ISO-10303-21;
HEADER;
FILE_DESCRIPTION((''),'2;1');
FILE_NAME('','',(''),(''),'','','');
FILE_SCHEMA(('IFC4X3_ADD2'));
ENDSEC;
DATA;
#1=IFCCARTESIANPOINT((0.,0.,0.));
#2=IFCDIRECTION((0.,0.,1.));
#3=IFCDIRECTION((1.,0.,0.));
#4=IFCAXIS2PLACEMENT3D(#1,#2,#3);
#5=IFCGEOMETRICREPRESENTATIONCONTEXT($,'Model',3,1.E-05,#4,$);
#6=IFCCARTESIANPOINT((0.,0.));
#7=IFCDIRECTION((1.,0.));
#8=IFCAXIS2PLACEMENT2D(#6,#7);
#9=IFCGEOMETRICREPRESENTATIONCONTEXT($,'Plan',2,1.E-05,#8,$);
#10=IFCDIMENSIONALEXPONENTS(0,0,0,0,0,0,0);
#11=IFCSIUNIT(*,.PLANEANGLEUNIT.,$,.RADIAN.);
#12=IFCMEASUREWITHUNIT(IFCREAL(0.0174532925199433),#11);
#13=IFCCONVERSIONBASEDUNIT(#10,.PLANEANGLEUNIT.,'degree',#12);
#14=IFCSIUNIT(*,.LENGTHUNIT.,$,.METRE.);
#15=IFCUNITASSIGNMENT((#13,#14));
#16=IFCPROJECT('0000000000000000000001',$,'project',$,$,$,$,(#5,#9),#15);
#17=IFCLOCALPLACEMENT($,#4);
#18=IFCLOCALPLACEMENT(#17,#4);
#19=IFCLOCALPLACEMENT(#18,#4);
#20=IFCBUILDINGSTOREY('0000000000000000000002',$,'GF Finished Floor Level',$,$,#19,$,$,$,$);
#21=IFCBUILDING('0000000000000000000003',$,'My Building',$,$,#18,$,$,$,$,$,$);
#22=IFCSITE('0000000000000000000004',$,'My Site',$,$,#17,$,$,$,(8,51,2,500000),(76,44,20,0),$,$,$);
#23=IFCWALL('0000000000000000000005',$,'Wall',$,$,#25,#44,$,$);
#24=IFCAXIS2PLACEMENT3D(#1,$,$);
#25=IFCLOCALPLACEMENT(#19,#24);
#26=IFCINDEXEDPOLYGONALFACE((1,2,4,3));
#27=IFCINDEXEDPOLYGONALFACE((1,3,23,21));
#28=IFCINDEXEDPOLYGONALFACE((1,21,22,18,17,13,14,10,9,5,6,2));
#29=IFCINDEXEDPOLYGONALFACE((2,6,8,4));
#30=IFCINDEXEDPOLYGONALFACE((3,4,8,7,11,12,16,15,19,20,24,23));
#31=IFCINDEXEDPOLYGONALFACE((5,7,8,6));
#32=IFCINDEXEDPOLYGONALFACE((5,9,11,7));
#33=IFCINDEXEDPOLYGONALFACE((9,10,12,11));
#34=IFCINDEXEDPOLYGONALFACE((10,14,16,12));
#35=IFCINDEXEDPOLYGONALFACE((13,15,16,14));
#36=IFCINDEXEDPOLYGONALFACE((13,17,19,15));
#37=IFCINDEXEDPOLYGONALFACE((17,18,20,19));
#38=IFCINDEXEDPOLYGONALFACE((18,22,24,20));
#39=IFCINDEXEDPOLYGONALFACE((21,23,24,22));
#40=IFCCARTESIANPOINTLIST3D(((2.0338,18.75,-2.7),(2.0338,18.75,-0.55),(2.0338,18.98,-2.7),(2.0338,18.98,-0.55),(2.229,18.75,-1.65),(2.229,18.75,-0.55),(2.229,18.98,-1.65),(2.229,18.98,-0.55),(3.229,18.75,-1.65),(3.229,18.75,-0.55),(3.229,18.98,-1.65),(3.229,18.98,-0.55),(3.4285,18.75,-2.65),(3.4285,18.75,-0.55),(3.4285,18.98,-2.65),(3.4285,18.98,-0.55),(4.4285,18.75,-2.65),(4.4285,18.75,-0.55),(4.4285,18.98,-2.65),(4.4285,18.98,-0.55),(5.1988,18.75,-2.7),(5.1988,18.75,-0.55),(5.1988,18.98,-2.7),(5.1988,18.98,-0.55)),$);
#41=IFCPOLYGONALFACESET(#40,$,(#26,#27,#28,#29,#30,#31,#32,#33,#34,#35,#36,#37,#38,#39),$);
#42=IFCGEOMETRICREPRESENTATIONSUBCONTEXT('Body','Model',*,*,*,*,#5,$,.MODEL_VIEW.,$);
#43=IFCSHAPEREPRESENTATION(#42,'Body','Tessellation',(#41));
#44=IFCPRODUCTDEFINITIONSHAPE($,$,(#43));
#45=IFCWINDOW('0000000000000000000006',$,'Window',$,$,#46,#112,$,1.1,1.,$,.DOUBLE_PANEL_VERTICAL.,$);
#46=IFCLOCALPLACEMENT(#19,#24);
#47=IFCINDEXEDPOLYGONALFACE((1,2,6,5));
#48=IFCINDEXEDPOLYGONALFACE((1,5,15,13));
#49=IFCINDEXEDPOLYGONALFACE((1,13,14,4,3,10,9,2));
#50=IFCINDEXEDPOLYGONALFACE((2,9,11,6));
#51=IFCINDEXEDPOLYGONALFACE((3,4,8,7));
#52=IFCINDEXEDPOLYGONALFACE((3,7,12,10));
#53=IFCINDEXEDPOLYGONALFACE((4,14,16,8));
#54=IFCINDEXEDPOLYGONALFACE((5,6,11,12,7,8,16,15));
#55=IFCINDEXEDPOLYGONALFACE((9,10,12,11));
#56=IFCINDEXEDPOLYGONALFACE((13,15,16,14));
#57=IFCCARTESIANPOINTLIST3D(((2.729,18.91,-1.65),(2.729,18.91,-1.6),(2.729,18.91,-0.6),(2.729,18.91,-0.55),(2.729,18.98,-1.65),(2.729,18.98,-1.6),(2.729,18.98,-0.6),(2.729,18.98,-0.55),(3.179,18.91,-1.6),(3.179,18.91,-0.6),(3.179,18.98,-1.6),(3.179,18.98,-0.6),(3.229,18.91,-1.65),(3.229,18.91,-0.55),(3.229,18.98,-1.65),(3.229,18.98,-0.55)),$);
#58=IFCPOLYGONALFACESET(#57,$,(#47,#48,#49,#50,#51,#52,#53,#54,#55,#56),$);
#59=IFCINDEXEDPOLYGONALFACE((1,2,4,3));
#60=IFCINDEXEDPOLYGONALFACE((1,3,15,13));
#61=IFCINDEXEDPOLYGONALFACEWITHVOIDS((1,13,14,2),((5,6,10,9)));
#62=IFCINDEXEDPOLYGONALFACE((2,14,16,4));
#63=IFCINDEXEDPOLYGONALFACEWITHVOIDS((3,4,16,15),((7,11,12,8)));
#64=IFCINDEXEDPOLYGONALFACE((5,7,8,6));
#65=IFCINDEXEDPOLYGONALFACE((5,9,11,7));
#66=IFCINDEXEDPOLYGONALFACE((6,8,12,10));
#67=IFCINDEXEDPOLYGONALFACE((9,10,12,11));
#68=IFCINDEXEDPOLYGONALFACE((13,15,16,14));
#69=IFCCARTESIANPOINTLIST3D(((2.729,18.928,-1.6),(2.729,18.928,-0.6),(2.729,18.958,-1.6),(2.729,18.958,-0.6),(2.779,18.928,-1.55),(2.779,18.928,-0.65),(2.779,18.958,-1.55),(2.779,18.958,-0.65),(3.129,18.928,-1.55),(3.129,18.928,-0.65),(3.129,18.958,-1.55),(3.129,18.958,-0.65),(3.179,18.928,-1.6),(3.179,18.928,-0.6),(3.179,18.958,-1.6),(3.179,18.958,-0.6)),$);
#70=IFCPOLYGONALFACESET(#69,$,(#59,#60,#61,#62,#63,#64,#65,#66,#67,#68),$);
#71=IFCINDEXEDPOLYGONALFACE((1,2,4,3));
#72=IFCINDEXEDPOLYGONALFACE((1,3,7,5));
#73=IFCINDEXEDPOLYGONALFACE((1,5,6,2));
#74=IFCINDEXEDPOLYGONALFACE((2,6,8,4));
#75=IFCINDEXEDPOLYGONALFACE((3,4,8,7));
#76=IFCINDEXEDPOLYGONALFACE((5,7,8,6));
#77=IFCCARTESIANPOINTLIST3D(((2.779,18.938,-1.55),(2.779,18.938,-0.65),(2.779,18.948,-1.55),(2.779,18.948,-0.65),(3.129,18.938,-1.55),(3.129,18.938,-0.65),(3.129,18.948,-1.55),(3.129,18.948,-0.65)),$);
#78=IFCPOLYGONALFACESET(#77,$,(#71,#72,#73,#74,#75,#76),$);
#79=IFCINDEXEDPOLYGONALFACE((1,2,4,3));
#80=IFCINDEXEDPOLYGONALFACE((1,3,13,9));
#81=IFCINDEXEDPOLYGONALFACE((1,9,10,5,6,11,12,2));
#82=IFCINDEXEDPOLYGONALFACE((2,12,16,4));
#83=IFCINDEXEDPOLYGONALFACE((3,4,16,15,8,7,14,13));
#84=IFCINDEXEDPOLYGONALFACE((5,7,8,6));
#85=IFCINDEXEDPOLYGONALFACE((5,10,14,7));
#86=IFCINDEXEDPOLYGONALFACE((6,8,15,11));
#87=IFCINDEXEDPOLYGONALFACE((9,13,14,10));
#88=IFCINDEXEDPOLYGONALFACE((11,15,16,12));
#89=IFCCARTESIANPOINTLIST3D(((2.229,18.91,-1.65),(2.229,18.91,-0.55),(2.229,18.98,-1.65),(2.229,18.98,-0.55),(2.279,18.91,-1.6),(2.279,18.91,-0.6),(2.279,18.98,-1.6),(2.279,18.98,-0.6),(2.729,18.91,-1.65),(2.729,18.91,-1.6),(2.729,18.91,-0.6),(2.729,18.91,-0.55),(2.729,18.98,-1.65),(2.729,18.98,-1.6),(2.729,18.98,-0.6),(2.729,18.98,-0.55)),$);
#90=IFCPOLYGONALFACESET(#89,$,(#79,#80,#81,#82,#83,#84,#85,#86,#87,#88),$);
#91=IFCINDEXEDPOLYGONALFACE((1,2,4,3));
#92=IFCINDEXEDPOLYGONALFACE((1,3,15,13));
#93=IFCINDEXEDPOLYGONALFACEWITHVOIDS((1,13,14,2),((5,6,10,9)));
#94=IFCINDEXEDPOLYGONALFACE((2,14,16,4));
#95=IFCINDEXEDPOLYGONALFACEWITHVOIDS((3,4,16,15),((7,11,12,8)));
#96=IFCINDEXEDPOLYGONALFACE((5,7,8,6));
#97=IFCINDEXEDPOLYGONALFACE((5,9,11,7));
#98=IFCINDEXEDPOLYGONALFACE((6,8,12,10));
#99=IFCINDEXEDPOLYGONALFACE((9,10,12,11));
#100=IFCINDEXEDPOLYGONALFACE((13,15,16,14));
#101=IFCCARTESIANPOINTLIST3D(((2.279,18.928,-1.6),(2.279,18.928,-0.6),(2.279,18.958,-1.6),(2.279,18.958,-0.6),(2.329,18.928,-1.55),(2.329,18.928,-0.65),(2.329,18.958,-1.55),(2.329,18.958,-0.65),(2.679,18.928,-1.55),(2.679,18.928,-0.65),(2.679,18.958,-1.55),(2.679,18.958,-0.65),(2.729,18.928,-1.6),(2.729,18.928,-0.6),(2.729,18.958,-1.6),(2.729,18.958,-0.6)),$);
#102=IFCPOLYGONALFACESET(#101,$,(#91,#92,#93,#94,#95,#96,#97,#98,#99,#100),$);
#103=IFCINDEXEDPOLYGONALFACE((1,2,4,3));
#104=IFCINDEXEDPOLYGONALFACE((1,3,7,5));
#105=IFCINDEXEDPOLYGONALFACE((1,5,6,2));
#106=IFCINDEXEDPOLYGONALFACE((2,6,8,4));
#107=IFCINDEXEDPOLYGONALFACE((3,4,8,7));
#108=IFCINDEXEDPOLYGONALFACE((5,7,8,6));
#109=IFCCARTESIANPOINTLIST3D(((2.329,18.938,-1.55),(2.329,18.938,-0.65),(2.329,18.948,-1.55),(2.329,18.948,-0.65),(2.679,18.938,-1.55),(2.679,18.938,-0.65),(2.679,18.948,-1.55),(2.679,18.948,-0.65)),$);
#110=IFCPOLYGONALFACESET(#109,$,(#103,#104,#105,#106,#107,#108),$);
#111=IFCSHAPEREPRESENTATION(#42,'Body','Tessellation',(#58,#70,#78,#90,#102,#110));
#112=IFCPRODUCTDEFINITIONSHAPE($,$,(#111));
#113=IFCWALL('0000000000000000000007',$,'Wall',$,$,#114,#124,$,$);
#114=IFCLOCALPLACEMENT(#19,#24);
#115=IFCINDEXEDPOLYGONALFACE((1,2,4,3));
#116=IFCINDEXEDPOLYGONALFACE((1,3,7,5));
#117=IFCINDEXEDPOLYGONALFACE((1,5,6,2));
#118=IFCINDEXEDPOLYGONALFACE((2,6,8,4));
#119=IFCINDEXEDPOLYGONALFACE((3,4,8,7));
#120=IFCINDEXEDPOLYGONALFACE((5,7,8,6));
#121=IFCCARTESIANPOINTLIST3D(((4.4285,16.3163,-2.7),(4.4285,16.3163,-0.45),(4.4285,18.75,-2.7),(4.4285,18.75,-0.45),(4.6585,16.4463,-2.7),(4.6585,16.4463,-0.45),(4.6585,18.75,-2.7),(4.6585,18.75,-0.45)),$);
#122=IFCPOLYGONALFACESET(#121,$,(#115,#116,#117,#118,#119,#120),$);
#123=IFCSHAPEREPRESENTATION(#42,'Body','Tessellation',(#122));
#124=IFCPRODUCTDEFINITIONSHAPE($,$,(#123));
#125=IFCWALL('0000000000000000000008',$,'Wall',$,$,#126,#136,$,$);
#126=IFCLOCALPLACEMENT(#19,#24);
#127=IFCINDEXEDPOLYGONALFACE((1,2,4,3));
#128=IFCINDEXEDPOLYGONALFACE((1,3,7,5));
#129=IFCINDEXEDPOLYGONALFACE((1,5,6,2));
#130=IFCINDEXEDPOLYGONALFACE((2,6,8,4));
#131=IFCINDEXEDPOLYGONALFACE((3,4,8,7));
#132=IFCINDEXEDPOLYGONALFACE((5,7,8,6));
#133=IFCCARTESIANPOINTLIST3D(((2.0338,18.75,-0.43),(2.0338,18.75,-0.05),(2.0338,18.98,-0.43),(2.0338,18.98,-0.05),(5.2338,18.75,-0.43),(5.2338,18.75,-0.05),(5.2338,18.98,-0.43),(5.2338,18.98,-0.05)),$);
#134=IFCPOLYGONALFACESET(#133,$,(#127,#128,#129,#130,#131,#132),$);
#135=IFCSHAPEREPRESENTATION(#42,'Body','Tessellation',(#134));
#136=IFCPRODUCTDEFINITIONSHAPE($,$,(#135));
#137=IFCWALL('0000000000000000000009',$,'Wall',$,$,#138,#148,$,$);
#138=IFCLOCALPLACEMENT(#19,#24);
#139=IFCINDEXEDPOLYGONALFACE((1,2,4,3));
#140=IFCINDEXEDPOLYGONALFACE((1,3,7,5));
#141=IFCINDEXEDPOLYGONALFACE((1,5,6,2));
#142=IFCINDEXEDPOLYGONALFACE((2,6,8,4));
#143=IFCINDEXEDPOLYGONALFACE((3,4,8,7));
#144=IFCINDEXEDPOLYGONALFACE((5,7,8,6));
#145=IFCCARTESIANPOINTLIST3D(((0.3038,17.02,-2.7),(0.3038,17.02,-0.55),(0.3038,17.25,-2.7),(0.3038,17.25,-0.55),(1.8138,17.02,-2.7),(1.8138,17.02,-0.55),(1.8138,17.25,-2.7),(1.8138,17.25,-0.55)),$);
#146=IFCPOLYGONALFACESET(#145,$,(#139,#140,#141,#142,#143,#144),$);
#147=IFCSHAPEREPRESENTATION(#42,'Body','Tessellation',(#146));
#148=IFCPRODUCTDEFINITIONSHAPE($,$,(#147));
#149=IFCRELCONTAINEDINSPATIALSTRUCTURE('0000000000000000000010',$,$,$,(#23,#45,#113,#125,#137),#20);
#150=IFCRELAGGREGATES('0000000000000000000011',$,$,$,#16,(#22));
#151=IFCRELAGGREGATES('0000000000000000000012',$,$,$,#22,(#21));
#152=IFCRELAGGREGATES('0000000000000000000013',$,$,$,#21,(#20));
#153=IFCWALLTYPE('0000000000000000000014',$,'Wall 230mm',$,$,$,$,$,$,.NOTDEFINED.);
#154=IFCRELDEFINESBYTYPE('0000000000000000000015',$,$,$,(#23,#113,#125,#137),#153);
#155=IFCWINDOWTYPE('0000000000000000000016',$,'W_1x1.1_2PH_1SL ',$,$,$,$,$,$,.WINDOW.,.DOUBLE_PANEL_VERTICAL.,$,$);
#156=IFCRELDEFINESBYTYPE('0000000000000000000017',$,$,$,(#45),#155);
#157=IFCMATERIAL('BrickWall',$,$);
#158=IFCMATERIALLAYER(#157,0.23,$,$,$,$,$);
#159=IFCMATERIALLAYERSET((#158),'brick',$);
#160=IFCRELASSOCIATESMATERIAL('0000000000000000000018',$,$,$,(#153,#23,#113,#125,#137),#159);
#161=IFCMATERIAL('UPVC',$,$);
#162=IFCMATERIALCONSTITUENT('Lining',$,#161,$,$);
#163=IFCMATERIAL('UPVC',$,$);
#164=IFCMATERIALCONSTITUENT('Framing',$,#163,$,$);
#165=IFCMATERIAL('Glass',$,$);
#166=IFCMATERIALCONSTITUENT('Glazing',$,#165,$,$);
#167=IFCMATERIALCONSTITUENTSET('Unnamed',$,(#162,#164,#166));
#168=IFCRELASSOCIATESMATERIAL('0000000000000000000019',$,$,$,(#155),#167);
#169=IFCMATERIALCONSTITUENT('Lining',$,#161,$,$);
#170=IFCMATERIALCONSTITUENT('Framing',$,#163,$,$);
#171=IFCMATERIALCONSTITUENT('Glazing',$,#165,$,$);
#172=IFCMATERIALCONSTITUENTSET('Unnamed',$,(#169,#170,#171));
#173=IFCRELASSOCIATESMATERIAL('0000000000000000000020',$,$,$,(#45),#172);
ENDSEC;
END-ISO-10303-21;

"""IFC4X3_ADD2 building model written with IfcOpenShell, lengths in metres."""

from ifc_helpers import new_model, entity, si_unit, converted_unit, frame, origin_with_axes, origin_2d_with_axis, place, context, subcontext, project, spatial, line, indexed_curve, outline, extrude, shape, source, transform, mapped, material, layer, layer_set, layer_usage, constituent, constituent_set, type_object, type_shapes, element, fill, save


model = new_model("IFC4X3_ADD2")

# Units and contexts
model_context = context("Model", 3, precision=1e-05, world=origin_with_axes())
plan_context = context("Plan", 2, precision=1e-05, world=origin_2d_with_axis())
body_context_1 = subcontext(model_context, "Body", "Model", "MODEL_VIEW")
body_context_2 = subcontext(plan_context, "Body", "Plan", "PLAN_VIEW")
ifc_project = project(units=[converted_unit("PLANEANGLEUNIT", "degree", entity("IfcReal", 0.0174532925199433), si_unit("PLANEANGLEUNIT", "RADIAN"), dimensions=[0, 0, 0, 0, 0, 0, 0]), si_unit("LENGTHUNIT", "METRE")], contexts=[model_context, plan_context])

# Site, building, storey
site_placement = place(None, origin_with_axes())
site = spatial("IfcSite", under=ifc_project, at=site_placement, Name="My Site", RefLatitude=(8, 51, 2, 500000), RefLongitude=(76, 44, 20, 0))
building_placement = place(site_placement, origin_with_axes())
building = spatial("IfcBuilding", under=site, at=building_placement, Name="My Building")
storey_placement = place(building_placement, origin_with_axes())
storey = spatial("IfcBuildingStorey", under=building, at=storey_placement, Name="GF Finished Floor Level")

# Wall, openings, window
ifc_material_1 = material(Name="BrickWall")
ifc_layer_1 = layer(ifc_material_1, 0.23)
ifc_layer_set_1 = layer_set([ifc_layer_1], Name="brick")
ifc_layer_usage_1 = layer_usage(ifc_layer_set_1, "AXIS2", "POSITIVE", 0.0)
wall_type_1 = type_object("IfcWallType", Name="Wall 230mm", PredefinedType="NOTDEFINED", material=ifc_layer_set_1)
wall_1_placement = place(storey_placement, frame((5.1988, 18.98, -2.7), z_axis=(0.0, 0.0, 1.0), x_axis=(-1.0, 0.0, 0.0)))
wall_1 = element("IfcWall", 1, at=wall_1_placement, inside=storey, type_object=wall_type_1, material=ifc_layer_usage_1, Name="Wall", context=body_context_1, shape_type="SweptSolid", body=[
    extrude(outline(indexed_curve([(0.0, 0.0), (0.0, 0.23), (3.165, 0.23), (3.165, 0.0)], segments=[line(1, 2, 3, 4, 1)])), origin_with_axes(), (0.0, 0.0, 1.0), 2.15),
])
shared_shape_1 = source(origin_with_axes(), body_context_1, "Body", "SweptSolid", [
    extrude(outline(indexed_curve([(0.0, 0.0), (1.0, 0.0), (1.0, 2.1), (0.0, 2.1)], segments=[line(1, 2, 3, 4, 1)])), frame((0.0, -0.6, 0.0), z_axis=(0.0, -1.0, 0.0), x_axis=(1.0, 0.0, 0.0)), (0.0, 0.0, -1.0), 1.2),
])
opening_1_placement = place(wall_1_placement, frame((0.7703, 0.0, 0.05), z_axis=(0.0, 0.0, 1.0), x_axis=(1.0, 0.0, 0.0)))
element("IfcOpeningElement", 2, at=opening_1_placement, cuts=wall_1, PredefinedType="OPENING", context=body_context_1, shape_type="MappedRepresentation", body=[
    mapped(shared_shape_1, transform((0.0, 0.0, 0.0), x_axis=(1.0, 0.0, 0.0), y_axis=(0.0, 1.0, 0.0), z_axis=(0.0, 0.0, 1.0), scale=1.0)),
])
shared_shape_2 = source(origin_with_axes(), body_context_1, "Body", "SweptSolid", [
    extrude(outline(indexed_curve([(0.0, 0.0), (1.0, 0.0), (1.0, 1.1), (0.0, 1.1)], segments=[line(1, 2, 3, 4, 1)])), frame((0.0, -0.6, 0.0), z_axis=(0.0, -1.0, 0.0), x_axis=(1.0, 0.0, 0.0)), (0.0, 0.0, -1.0), 1.2),
])
opening_2_placement = place(wall_1_placement, frame((1.9699, 0.0, 1.05), z_axis=(0.0, 0.0, 1.0), x_axis=(1.0, 0.0, 0.0)))
opening_2 = element("IfcOpeningElement", 3, at=opening_2_placement, cuts=wall_1, PredefinedType="OPENING", context=body_context_1, shape_type="MappedRepresentation", body=[
    mapped(shared_shape_2, transform((0.0, 0.0, 0.0), x_axis=(1.0, 0.0, 0.0), y_axis=(0.0, 1.0, 0.0), z_axis=(0.0, 0.0, 1.0), scale=1.0)),
])
ifc_material_2 = material(Name="UPVC")
ifc_constituent_1 = constituent(ifc_material_2, Name="Lining")
ifc_material_3 = material(Name="UPVC")
ifc_constituent_2 = constituent(ifc_material_3, Name="Framing")
ifc_material_4 = material(Name="Glass")
ifc_constituent_3 = constituent(ifc_material_4, Name="Glazing")
ifc_constituent_set_1 = constituent_set(constituents=[ifc_constituent_1, ifc_constituent_2, ifc_constituent_3], Name="Unnamed")
ifc_constituent_4 = constituent(ifc_material_2, Name="Lining")
ifc_constituent_5 = constituent(ifc_material_3, Name="Framing")
ifc_constituent_6 = constituent(ifc_material_4, Name="Glazing")
ifc_constituent_set_2 = constituent_set(constituents=[ifc_constituent_4, ifc_constituent_5, ifc_constituent_6], Name="Unnamed")
window_type = type_object("IfcWindowType", Name="W_1x1.1_2PH_1SL ", PartitioningType="DOUBLE_PANEL_VERTICAL", PredefinedType="WINDOW", material=ifc_constituent_set_2)
shared_shape_3 = source(origin_with_axes(), body_context_1, "Body", "SweptSolid", [
    extrude(outline(indexed_curve([(0.5, 0.0), (0.0, 0.0), (0.0, 1.1), (0.5, 1.1), (0.5, 1.05), (0.05, 1.05), (0.05, 0.05), (0.5, 0.05)], segments=[line(1, 2, 3, 4, 5, 6, 7, 8, 1)])), frame((0.0, 0.0, 0.0), z_axis=(0.0, -1.0, 0.0), x_axis=(1.0, 0.0, 0.0)), (0.0, 0.0, -1.0), 0.07),
    extrude(outline(indexed_curve([(0.0, 0.0), (0.45, 0.0), (0.45, 1.0), (0.0, 1.0)], segments=[line(1, 2, 3, 4, 1)]), holes=[indexed_curve([(0.05, 0.05), (0.4, 0.05), (0.4, 0.95), (0.05, 0.95)], segments=[line(1, 2, 3, 4, 1)])]), frame((0.05, 0.022, 0.05), z_axis=(0.0, -1.0, 0.0), x_axis=(1.0, 0.0, 0.0)), (0.0, 0.0, -1.0), 0.03),
    extrude(outline(indexed_curve([(0.05, 0.05), (0.4, 0.05), (0.4, 0.95), (0.05, 0.95)], segments=[line(1, 2, 3, 4, 1)])), frame((0.05, 0.032, 0.05), z_axis=(0.0, -1.0, 0.0), x_axis=(1.0, 0.0, 0.0)), (0.0, 0.0, -1.0), 0.01),
    extrude(outline(indexed_curve([(0.0, 1.1), (0.5, 1.1), (0.5, 0.0), (0.0, 0.0), (0.0, 0.05), (0.45, 0.05), (0.45, 1.05), (0.0, 1.05)], segments=[line(1, 2, 3, 4, 5, 6, 7, 8, 1)])), frame((0.5, 0.0, 0.0), z_axis=(0.0, -1.0, 0.0), x_axis=(1.0, 0.0, 0.0)), (0.0, 0.0, -1.0), 0.07),
    extrude(outline(indexed_curve([(0.0, 0.0), (0.45, 0.0), (0.45, 1.0), (0.0, 1.0)], segments=[line(1, 2, 3, 4, 1)]), holes=[indexed_curve([(0.05, 0.05), (0.4, 0.05), (0.4, 0.95), (0.05, 0.95)], segments=[line(1, 2, 3, 4, 1)])]), frame((0.5, 0.022, 0.05), z_axis=(0.0, -1.0, 0.0), x_axis=(1.0, 0.0, 0.0)), (0.0, 0.0, -1.0), 0.03),
    extrude(outline(indexed_curve([(0.05, 0.05), (0.4, 0.05), (0.4, 0.95), (0.05, 0.95)], segments=[line(1, 2, 3, 4, 1)])), frame((0.5, 0.032, 0.05), z_axis=(0.0, -1.0, 0.0), x_axis=(1.0, 0.0, 0.0)), (0.0, 0.0, -1.0), 0.01),
])
shared_shape_4 = source(origin_with_axes(), body_context_2, "Body", "Curve2D", [
    entity("IfcIndexedPolyCurve", entity("IfcCartesianPointList2D", [[0.05, 0.0], [0.5, 0.0]])),
    entity("IfcIndexedPolyCurve", entity("IfcCartesianPointList2D", [[0.0, 0.07], [0.05, 0.07], [0.05, 0.0], [0.0, 0.0]]), [entity("IfcLineIndex", [1, 2, 3, 4, 1])]),
    entity("IfcIndexedPolyCurve", entity("IfcCartesianPointList2D", [[0.5, 0.07], [0.5, 0.07], [0.5, 0.0], [0.5, 0.0]])),
    entity("IfcIndexedPolyCurve", entity("IfcCartesianPointList2D", [[0.05, 0.022], [0.1, 0.022], [0.1, 0.052], [0.05, 0.052]]), [entity("IfcLineIndex", [1, 2, 3, 4, 1])]),
    entity("IfcIndexedPolyCurve", entity("IfcCartesianPointList2D", [[0.5, 0.022], [0.45, 0.022], [0.45, 0.052], [0.5, 0.052]]), [entity("IfcLineIndex", [1, 2, 3, 4, 1])]),
    entity("IfcIndexedPolyCurve", entity("IfcCartesianPointList2D", [[0.1, 0.022], [0.45, 0.022]])),
    entity("IfcIndexedPolyCurve", entity("IfcCartesianPointList2D", [[0.1, 0.052], [0.45, 0.052]])),
    entity("IfcIndexedPolyCurve", entity("IfcCartesianPointList2D", [[0.1, 0.037], [0.45, 0.037]])),
    entity("IfcIndexedPolyCurve", entity("IfcCartesianPointList2D", [[0.5, 0.0], [0.95, 0.0]])),
    entity("IfcIndexedPolyCurve", entity("IfcCartesianPointList2D", [[0.5, 0.07], [0.5, 0.07], [0.5, 0.0], [0.5, 0.0]])),
    entity("IfcIndexedPolyCurve", entity("IfcCartesianPointList2D", [[1.0, 0.07], [0.95, 0.07], [0.95, 0.0], [1.0, 0.0]]), [entity("IfcLineIndex", [1, 2, 3, 4, 1])]),
    entity("IfcIndexedPolyCurve", entity("IfcCartesianPointList2D", [[0.5, 0.022], [0.55, 0.022], [0.55, 0.052], [0.5, 0.052]]), [entity("IfcLineIndex", [1, 2, 3, 4, 1])]),
    entity("IfcIndexedPolyCurve", entity("IfcCartesianPointList2D", [[0.95, 0.022], [0.9, 0.022], [0.9, 0.052], [0.95, 0.052]]), [entity("IfcLineIndex", [1, 2, 3, 4, 1])]),
    entity("IfcIndexedPolyCurve", entity("IfcCartesianPointList2D", [[0.55, 0.022], [0.9, 0.022]])),
    entity("IfcIndexedPolyCurve", entity("IfcCartesianPointList2D", [[0.55, 0.052], [0.9, 0.052]])),
    entity("IfcIndexedPolyCurve", entity("IfcCartesianPointList2D", [[0.55, 0.037], [0.9, 0.037]])),
])
type_shapes(window_type, [shared_shape_3, shared_shape_4])
window_placement = place(opening_2_placement, frame((0.0, 0.0, 0.0), z_axis=(0.0, 0.0, 1.0), x_axis=(1.0, 0.0, 0.0)))
window = element("IfcWindow", 4, at=window_placement, inside=storey, type_object=window_type, material=ifc_constituent_set_1, Name="Window", OverallHeight=1.1, OverallWidth=1.0, PartitioningType="DOUBLE_PANEL_VERTICAL", shapes=[
    shape(body_context_1, "Body", "MappedRepresentation", [mapped(shared_shape_3, transform((0.0, 0.0, 0.0), x_axis=(1.0, 0.0, 0.0), y_axis=(0.0, 1.0, 0.0), z_axis=(0.0, 0.0, 1.0), scale=1.0))]),
    shape(body_context_2, "Body", "MappedRepresentation", [mapped(shared_shape_4, transform((0.0, 0.0, 0.0), x_axis=(1.0, 0.0, 0.0), y_axis=(0.0, 1.0, 0.0), z_axis=(0.0, 0.0, 1.0), scale=1.0))]),
])
fill(opening_2, window)

# Walls
ifc_layer_usage_2 = layer_usage(ifc_layer_set_1, "AXIS2", "POSITIVE", 0.0)
wall_2_placement = place(storey_placement, frame((4.4285, 18.75, -2.7), z_axis=(0.0, 0.0, 1.0), x_axis=(0.0, -1.0, 0.0)))
element("IfcWall", 5, at=wall_2_placement, inside=storey, type_object=wall_type_1, material=ifc_layer_usage_2, Name="Wall", context=body_context_1, shape_type="SweptSolid", body=[
    extrude(outline(indexed_curve([(0.0, 0.0), (0.0, 0.23), (2.3037, 0.23), (2.4337, 0.0)], segments=[line(1, 2, 3, 4, 1)])), origin_with_axes(), (0.0, 0.0, 1.0), 2.25),
])
ifc_layer_usage_3 = layer_usage(ifc_layer_set_1, "AXIS2", "POSITIVE", 0.0)
wall_3_placement = place(storey_placement, frame((5.2338, 18.98, -0.43), z_axis=(0.0, 0.0, 1.0), x_axis=(-1.0, 0.0, 0.0)))
element("IfcWall", 6, at=wall_3_placement, inside=storey, type_object=wall_type_1, material=ifc_layer_usage_3, Name="Wall", context=body_context_1, shape_type="SweptSolid", body=[
    extrude(outline(indexed_curve([(0.0, 0.0), (0.0, 0.23), (3.2, 0.23), (3.2, 0.0)], segments=[line(1, 2, 3, 4, 1)])), origin_with_axes(), (0.0, 0.0, 1.0), 0.38),
])
ifc_layer_usage_4 = layer_usage(ifc_layer_set_1, "AXIS2", "POSITIVE", 0.0)
wall_4_placement = place(storey_placement, frame((1.8138, 17.25, -2.7), z_axis=(0.0, 0.0, 1.0), x_axis=(-1.0, 0.0, 0.0)))
element("IfcWall", 7, at=wall_4_placement, inside=storey, type_object=wall_type_1, material=ifc_layer_usage_4, Name="Wall", context=body_context_1, shape_type="SweptSolid", body=[
    extrude(outline(indexed_curve([(0.0, 0.0), (0.0, 0.23), (1.51, 0.23), (1.51, 0.0)], segments=[line(1, 2, 3, 4, 1)])), origin_with_axes(), (0.0, 0.0, 1.0), 2.15),
])

save(model, "model.ifc")
